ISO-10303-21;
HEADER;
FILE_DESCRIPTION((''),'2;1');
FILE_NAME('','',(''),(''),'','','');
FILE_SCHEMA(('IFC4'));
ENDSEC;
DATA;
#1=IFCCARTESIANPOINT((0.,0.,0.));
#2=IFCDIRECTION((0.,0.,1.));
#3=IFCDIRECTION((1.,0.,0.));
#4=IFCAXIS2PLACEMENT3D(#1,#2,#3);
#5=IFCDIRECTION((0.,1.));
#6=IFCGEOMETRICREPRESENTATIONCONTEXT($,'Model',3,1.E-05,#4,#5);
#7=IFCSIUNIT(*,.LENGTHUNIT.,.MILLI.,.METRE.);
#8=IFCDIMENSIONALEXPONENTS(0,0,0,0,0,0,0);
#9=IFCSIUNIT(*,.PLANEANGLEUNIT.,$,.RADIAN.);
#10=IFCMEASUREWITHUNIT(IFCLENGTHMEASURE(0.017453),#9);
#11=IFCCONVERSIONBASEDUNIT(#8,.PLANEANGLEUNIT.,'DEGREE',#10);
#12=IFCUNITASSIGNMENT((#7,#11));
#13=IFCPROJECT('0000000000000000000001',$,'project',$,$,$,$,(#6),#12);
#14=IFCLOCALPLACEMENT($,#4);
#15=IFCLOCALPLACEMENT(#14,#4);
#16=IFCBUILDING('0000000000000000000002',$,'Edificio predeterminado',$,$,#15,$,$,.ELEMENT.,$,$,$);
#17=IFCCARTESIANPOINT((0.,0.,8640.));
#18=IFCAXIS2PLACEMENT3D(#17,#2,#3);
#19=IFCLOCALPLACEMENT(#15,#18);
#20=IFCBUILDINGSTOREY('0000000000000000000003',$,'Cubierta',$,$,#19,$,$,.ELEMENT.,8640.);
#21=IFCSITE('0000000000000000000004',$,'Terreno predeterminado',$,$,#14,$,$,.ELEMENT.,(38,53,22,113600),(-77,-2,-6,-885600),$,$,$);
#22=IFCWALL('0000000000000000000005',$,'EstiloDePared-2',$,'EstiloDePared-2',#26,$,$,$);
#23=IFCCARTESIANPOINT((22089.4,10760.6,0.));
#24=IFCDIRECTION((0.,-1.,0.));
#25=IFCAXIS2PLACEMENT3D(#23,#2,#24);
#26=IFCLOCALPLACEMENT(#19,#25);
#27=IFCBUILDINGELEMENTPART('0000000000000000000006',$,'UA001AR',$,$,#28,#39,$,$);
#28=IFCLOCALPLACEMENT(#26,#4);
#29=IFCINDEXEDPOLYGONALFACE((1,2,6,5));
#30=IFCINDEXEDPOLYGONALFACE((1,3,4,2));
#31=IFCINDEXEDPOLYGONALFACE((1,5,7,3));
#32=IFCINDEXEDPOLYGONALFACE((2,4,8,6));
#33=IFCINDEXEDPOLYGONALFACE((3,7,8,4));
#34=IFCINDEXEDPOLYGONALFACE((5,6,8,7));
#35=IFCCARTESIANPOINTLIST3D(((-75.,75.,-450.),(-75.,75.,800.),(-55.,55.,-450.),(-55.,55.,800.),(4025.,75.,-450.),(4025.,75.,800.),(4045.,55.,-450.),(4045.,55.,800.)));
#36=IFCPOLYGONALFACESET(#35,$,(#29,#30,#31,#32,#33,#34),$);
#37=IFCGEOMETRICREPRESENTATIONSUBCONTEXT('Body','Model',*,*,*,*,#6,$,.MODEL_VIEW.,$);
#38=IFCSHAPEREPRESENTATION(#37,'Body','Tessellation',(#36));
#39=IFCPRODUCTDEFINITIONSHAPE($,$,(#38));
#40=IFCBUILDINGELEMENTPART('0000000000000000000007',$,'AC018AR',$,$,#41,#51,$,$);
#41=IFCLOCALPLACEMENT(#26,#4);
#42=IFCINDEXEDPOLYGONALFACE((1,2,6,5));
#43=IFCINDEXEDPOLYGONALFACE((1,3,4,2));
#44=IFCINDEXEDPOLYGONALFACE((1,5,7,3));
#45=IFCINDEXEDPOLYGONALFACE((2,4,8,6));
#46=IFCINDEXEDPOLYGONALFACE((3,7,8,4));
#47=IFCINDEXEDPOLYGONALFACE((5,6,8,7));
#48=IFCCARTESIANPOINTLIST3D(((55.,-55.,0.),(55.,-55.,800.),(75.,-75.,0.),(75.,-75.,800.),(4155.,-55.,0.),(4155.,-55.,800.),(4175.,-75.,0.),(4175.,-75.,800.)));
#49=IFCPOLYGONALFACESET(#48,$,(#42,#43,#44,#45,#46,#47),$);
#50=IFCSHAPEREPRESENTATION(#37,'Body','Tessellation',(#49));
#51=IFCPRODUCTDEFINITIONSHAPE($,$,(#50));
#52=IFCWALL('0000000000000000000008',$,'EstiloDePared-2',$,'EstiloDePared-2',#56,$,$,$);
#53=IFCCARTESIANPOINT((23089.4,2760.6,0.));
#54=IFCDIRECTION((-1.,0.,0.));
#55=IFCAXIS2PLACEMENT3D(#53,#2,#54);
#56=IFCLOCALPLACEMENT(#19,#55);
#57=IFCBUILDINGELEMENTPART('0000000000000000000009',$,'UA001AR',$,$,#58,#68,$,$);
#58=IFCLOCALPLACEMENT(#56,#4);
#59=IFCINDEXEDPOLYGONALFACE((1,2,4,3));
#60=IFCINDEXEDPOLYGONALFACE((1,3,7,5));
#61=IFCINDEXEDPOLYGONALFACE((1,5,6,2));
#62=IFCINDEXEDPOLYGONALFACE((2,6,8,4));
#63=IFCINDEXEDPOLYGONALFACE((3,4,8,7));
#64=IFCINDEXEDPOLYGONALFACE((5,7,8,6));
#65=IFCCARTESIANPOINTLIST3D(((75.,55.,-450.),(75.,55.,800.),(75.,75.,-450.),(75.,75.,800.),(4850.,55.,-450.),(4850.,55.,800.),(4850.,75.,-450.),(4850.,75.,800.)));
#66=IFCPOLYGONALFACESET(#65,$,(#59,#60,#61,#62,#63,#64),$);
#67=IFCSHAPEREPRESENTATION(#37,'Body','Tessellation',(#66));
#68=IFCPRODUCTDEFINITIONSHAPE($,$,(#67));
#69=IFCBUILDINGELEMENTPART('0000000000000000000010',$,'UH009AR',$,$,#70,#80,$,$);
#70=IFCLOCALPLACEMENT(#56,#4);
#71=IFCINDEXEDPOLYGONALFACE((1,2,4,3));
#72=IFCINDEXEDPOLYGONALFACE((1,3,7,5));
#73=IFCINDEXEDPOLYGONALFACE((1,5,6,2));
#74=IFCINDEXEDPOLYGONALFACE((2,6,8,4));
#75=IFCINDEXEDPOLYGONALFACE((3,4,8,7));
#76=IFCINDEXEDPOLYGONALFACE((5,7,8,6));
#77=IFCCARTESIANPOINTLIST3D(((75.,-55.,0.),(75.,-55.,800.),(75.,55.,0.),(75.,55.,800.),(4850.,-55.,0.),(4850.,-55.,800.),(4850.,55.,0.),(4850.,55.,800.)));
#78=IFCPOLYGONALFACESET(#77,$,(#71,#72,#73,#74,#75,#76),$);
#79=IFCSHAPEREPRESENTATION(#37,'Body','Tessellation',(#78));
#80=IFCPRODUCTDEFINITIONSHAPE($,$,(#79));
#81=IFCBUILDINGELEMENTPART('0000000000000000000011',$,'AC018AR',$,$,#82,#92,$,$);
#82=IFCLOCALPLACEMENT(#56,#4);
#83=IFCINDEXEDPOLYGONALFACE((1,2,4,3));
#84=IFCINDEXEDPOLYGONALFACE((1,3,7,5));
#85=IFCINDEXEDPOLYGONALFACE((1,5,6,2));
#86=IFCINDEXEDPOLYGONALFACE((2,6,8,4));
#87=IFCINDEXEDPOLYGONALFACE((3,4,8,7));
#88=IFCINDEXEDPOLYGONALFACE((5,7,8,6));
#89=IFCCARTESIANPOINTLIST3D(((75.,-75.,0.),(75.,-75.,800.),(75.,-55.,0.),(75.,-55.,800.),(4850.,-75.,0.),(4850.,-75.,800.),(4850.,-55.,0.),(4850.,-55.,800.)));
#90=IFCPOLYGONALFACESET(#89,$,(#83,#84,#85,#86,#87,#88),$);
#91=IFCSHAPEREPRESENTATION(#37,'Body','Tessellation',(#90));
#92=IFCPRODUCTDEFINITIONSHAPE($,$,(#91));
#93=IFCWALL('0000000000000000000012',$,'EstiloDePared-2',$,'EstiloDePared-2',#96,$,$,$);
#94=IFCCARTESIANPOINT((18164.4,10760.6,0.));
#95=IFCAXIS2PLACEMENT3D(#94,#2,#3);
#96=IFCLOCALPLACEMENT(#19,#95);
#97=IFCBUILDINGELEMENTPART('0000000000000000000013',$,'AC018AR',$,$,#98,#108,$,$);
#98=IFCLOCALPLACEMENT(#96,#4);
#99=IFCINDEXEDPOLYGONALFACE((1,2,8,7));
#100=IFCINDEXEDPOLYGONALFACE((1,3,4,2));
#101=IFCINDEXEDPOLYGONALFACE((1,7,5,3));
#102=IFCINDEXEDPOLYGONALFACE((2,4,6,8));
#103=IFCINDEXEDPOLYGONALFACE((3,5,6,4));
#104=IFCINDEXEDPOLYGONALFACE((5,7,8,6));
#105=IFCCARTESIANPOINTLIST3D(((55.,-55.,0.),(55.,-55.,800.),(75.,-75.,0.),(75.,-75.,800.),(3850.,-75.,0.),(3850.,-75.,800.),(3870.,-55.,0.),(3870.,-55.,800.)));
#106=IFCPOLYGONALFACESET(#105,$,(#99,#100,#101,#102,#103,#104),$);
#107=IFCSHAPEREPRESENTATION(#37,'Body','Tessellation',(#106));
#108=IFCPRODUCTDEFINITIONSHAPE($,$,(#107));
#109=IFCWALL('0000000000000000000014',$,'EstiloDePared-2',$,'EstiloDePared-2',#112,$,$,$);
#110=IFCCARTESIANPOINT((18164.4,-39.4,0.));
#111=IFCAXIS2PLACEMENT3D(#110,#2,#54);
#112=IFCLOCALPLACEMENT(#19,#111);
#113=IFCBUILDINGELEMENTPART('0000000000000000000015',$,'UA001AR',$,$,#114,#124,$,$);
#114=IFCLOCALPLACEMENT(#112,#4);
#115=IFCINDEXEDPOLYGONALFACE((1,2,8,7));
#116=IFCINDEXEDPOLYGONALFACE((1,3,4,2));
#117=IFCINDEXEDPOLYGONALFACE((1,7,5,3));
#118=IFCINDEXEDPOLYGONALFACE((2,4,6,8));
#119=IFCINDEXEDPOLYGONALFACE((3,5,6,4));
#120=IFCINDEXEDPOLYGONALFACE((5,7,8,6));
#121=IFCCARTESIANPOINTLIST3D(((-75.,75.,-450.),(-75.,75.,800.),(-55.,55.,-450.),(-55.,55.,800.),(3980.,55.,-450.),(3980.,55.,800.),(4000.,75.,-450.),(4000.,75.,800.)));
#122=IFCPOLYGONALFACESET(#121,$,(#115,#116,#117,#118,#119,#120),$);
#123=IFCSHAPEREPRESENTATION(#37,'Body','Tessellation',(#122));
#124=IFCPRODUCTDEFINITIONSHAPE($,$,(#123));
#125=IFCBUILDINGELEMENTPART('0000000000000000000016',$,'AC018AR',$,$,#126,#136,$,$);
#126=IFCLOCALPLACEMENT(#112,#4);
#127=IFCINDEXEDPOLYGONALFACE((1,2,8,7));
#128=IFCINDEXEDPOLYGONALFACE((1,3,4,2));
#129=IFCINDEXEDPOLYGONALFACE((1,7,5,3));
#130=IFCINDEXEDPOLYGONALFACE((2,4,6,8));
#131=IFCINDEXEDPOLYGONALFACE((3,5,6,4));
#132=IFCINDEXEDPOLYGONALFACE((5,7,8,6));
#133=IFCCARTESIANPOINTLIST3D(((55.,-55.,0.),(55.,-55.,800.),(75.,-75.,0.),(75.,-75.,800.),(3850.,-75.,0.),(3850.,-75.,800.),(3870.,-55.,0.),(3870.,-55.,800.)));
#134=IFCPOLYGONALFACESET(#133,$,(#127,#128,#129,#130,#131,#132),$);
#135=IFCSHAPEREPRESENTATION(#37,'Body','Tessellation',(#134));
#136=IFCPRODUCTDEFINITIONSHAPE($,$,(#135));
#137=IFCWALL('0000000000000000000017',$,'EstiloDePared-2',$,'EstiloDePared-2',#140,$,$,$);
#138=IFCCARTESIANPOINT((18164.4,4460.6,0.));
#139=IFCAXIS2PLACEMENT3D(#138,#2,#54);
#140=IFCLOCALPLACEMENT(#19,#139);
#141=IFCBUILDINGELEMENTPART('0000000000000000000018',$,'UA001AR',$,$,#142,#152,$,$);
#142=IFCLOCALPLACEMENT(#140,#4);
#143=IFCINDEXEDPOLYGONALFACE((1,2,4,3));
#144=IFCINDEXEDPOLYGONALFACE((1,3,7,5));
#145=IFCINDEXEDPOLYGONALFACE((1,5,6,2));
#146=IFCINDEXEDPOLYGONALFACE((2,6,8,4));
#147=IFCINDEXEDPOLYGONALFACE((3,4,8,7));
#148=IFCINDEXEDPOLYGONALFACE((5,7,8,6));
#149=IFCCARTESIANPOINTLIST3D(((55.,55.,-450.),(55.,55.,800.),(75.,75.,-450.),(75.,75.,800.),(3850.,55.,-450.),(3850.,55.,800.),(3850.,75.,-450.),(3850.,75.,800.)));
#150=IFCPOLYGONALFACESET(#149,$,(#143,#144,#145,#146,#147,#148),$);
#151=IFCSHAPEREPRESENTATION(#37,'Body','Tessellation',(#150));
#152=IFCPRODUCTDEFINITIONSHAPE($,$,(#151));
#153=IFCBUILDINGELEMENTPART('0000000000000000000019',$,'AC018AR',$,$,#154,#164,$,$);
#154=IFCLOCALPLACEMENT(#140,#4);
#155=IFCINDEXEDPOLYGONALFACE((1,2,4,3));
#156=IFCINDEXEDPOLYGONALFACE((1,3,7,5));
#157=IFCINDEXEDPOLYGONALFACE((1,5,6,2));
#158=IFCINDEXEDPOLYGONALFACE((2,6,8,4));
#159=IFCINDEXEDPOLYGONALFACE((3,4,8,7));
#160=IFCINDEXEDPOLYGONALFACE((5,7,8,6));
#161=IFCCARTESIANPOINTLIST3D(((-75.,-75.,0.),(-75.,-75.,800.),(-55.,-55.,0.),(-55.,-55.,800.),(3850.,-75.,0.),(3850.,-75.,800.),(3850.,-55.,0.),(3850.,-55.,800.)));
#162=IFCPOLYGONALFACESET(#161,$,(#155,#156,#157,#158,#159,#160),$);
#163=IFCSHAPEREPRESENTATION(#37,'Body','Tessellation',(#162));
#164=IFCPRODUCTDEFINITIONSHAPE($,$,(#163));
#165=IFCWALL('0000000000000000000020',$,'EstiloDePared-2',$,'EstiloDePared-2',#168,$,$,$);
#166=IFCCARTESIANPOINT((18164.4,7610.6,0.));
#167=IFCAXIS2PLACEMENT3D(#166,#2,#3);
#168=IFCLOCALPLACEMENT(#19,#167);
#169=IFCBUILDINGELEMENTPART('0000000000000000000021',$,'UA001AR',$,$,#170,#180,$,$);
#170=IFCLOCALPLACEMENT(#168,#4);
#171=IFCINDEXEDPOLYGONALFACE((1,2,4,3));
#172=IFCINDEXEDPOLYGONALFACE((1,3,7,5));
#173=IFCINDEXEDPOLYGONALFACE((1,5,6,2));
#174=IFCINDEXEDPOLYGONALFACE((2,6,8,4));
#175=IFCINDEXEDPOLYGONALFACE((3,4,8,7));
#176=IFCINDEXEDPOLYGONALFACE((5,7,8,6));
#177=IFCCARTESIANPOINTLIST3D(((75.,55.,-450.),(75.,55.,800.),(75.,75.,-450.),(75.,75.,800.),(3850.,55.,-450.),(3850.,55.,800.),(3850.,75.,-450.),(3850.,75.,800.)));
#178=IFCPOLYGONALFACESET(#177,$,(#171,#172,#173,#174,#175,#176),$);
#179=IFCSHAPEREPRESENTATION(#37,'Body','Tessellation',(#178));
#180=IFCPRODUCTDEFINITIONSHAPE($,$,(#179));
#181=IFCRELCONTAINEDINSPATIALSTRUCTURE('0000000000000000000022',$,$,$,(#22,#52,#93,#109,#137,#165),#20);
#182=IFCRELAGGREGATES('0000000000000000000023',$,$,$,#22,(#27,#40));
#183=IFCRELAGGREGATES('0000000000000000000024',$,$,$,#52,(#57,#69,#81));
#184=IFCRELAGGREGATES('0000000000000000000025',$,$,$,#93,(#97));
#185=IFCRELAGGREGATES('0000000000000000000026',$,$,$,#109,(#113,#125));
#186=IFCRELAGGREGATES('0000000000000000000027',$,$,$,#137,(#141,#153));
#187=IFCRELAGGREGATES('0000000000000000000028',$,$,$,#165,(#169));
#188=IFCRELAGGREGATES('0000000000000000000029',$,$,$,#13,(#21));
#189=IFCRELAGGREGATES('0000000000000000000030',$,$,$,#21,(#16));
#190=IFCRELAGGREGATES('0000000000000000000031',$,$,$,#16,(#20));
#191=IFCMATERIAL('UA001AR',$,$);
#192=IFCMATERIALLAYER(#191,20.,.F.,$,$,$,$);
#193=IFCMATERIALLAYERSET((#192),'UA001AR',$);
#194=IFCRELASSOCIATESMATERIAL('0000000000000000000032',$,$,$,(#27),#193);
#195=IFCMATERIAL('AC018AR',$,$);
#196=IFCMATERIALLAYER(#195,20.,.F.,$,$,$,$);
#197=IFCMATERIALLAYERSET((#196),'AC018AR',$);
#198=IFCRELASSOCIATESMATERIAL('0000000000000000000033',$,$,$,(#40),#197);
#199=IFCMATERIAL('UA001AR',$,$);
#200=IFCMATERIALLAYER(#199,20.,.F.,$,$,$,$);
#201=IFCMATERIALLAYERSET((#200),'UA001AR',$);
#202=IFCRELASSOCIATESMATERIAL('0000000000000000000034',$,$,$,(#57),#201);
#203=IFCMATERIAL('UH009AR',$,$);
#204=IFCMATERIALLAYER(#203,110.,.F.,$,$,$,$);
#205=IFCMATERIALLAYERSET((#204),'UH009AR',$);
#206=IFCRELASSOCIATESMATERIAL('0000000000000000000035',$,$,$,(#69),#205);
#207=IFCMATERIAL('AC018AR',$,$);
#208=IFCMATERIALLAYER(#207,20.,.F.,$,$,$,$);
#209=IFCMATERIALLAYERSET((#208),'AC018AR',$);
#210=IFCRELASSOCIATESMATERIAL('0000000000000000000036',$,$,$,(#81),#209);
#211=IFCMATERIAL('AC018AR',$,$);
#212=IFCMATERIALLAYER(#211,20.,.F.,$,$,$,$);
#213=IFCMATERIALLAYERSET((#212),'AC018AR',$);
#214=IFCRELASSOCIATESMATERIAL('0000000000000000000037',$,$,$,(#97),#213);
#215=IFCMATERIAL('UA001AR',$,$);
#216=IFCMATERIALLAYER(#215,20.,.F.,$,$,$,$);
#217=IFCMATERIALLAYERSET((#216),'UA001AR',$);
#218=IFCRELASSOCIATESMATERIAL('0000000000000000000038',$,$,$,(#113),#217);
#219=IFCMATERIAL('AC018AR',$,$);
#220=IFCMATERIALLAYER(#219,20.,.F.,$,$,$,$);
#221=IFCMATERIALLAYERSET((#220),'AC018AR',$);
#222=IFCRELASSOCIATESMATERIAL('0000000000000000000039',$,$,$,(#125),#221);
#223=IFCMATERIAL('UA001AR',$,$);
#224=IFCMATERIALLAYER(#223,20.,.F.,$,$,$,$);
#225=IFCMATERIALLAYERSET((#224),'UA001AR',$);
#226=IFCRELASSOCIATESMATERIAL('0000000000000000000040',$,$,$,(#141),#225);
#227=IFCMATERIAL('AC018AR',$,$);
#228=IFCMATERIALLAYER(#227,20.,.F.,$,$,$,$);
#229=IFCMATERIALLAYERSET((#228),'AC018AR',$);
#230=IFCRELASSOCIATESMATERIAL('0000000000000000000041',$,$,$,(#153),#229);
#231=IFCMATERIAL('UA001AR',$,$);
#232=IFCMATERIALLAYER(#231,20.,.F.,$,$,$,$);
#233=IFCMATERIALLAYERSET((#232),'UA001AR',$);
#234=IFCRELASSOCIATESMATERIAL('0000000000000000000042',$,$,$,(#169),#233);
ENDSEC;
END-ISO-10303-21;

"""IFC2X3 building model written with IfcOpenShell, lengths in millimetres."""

from ifc_helpers import new_model, entity, si_unit, converted_unit, direction, frame, origin_with_axes, place, context, subcontext, project, spatial, polyline, outline, extrude, material, layer, layer_set, layer_usage, element, aggregate, save


model = new_model("IFC2X3")

# Units and contexts
model_context = context("Model", 3, precision=1e-05, world=origin_with_axes(), true_north=direction((0.0, 1.0)))
body_context = subcontext(model_context, "Body", "Model", "MODEL_VIEW")
ifc_project = project(units=[si_unit("LENGTHUNIT", "METRE", prefix="MILLI"), converted_unit("PLANEANGLEUNIT", "DEGREE", entity("IfcLengthMeasure", 0.017453), si_unit("PLANEANGLEUNIT", "RADIAN"), dimensions=[0, 0, 0, 0, 0, 0, 0])], contexts=[model_context])

# Site, building, storey
site_placement = place(None, origin_with_axes())
site = spatial("IfcSite", under=ifc_project, at=site_placement, Name="Terreno predeterminado", CompositionType="ELEMENT", RefLatitude=(38, 53, 22, 113600), RefLongitude=(-77, -2, -6, -885600))
building_placement = place(site_placement, origin_with_axes())
building = spatial("IfcBuilding", under=site, at=building_placement, Name="Edificio predeterminado", CompositionType="ELEMENT")
storey_placement = place(building_placement, frame((0.0, 0.0, 8640.0), z_axis=(0.0, 0.0, 1.0), x_axis=(1.0, 0.0, 0.0)))
storey = spatial("IfcBuildingStorey", under=building, at=storey_placement, Name="Cubierta", CompositionType="ELEMENT", Elevation=8640.0)

# Walls, building element parts
wall_1_placement = place(storey_placement, frame((22089.4, 10760.6, 0.0), z_axis=(0.0, 0.0, 1.0), x_axis=(0.0, -1.0, 0.0)))
wall_1 = element("IfcWall", 1, at=wall_1_placement, inside=storey, Name="EstiloDePared-2", ObjectType="EstiloDePared-2")
ifc_material_1 = material(Name="UA001AR")
ifc_layer_1 = layer(ifc_material_1, 20.0, ventilated=False)
ifc_layer_set_1 = layer_set([ifc_layer_1], Name="UA001AR")
ifc_layer_usage_1 = layer_usage(ifc_layer_set_1, "AXIS2", "NEGATIVE", -75.0)
building_element_part_1_placement = place(wall_1_placement, origin_with_axes())
building_element_part_1 = element("IfcBuildingElementPart", 2, at=building_element_part_1_placement, material=ifc_layer_usage_1, Name="UA001AR", context=body_context, shape_type="SweptSolid", body=[
    extrude(outline(polyline([(4025.0, 75.0), (4045.0, 55.0), (-55.0, 55.0), (-75.0, 75.0), (4025.0, 75.0)])), frame((0.0, 0.0, -450.0), z_axis=(0.0, 0.0, 1.0), x_axis=(1.0, 0.0, 0.0)), (0.0, 0.0, 1.0), 1250.0),
])
ifc_material_2 = material(Name="AC018AR")
ifc_layer_2 = layer(ifc_material_2, 20.0, ventilated=False)
ifc_layer_set_2 = layer_set([ifc_layer_2], Name="AC018AR")
ifc_layer_usage_2 = layer_usage(ifc_layer_set_2, "AXIS2", "NEGATIVE", 55.0)
building_element_part_2_placement = place(wall_1_placement, origin_with_axes())
building_element_part_2 = element("IfcBuildingElementPart", 3, at=building_element_part_2_placement, material=ifc_layer_usage_2, Name="AC018AR", context=body_context, shape_type="SweptSolid", body=[
    extrude(outline(polyline([(4155.0, -55.0), (4175.0, -75.0), (75.0, -75.0), (55.0, -55.0), (4155.0, -55.0)])), origin_with_axes(), (0.0, 0.0, 1.0), 800.0),
])
aggregate(wall_1, [building_element_part_1, building_element_part_2])
wall_2_placement = place(storey_placement, frame((23089.4, 2760.6, 0.0), z_axis=(0.0, 0.0, 1.0), x_axis=(-1.0, 0.0, 0.0)))
wall_2 = element("IfcWall", 4, at=wall_2_placement, inside=storey, Name="EstiloDePared-2", ObjectType="EstiloDePared-2")
ifc_material_3 = material(Name="UA001AR")
ifc_layer_3 = layer(ifc_material_3, 20.0, ventilated=False)
ifc_layer_set_3 = layer_set([ifc_layer_3], Name="UA001AR")
ifc_layer_usage_3 = layer_usage(ifc_layer_set_3, "AXIS2", "NEGATIVE", -75.0)
building_element_part_3_placement = place(wall_2_placement, origin_with_axes())
building_element_part_3 = element("IfcBuildingElementPart", 5, at=building_element_part_3_placement, material=ifc_layer_usage_3, Name="UA001AR", context=body_context, shape_type="SweptSolid", body=[
    extrude(outline(polyline([(4850.0, 75.0), (4850.0, 55.0), (75.0, 55.0), (75.0, 75.0), (4850.0, 75.0)])), frame((0.0, 0.0, -450.0), z_axis=(0.0, 0.0, 1.0), x_axis=(1.0, 0.0, 0.0)), (0.0, 0.0, 1.0), 1250.0),
])
ifc_material_4 = material(Name="UH009AR")
ifc_layer_4 = layer(ifc_material_4, 110.0, ventilated=False)
ifc_layer_set_4 = layer_set([ifc_layer_4], Name="UH009AR")
ifc_layer_usage_4 = layer_usage(ifc_layer_set_4, "AXIS2", "NEGATIVE", -55.0)
building_element_part_4_placement = place(wall_2_placement, origin_with_axes())
building_element_part_4 = element("IfcBuildingElementPart", 6, at=building_element_part_4_placement, material=ifc_layer_usage_4, Name="UH009AR", context=body_context, shape_type="SweptSolid", body=[
    extrude(outline(polyline([(4850.0, 55.0), (4850.0, -55.0), (75.0, -55.0), (75.0, 55.0), (4850.0, 55.0)])), origin_with_axes(), (0.0, 0.0, 1.0), 800.0),
])
ifc_material_5 = material(Name="AC018AR")
ifc_layer_5 = layer(ifc_material_5, 20.0, ventilated=False)
ifc_layer_set_5 = layer_set([ifc_layer_5], Name="AC018AR")
ifc_layer_usage_5 = layer_usage(ifc_layer_set_5, "AXIS2", "NEGATIVE", 55.0)
building_element_part_5_placement = place(wall_2_placement, origin_with_axes())
building_element_part_5 = element("IfcBuildingElementPart", 7, at=building_element_part_5_placement, material=ifc_layer_usage_5, Name="AC018AR", context=body_context, shape_type="SweptSolid", body=[
    extrude(outline(polyline([(4850.0, -55.0), (4850.0, -75.0), (75.0, -75.0), (75.0, -55.0), (4850.0, -55.0)])), origin_with_axes(), (0.0, 0.0, 1.0), 800.0),
])
aggregate(wall_2, [building_element_part_3, building_element_part_4, building_element_part_5])

# Wall, building element part
wall_3_placement = place(storey_placement, frame((18164.4, 10760.6, 0.0), z_axis=(0.0, 0.0, 1.0), x_axis=(1.0, 0.0, 0.0)))
wall_3 = element("IfcWall", 8, at=wall_3_placement, inside=storey, Name="EstiloDePared-2", ObjectType="EstiloDePared-2")
ifc_material_6 = material(Name="AC018AR")
ifc_layer_6 = layer(ifc_material_6, 20.0, ventilated=False)
ifc_layer_set_6 = layer_set([ifc_layer_6], Name="AC018AR")
ifc_layer_usage_6 = layer_usage(ifc_layer_set_6, "AXIS2", "NEGATIVE", 55.0)
building_element_part_6_placement = place(wall_3_placement, origin_with_axes())
building_element_part_6 = element("IfcBuildingElementPart", 9, at=building_element_part_6_placement, material=ifc_layer_usage_6, Name="AC018AR", context=body_context, shape_type="SweptSolid", body=[
    extrude(outline(polyline([(3870.0, -55.0), (3850.0, -75.0), (75.0, -75.0), (55.0, -55.0), (3870.0, -55.0)])), origin_with_axes(), (0.0, 0.0, 1.0), 800.0),
])
aggregate(wall_3, [building_element_part_6])

# Walls, building element parts
wall_4_placement = place(storey_placement, frame((18164.4, -39.4, 0.0), z_axis=(0.0, 0.0, 1.0), x_axis=(-1.0, 0.0, 0.0)))
wall_4 = element("IfcWall", 10, at=wall_4_placement, inside=storey, Name="EstiloDePared-2", ObjectType="EstiloDePared-2")
ifc_material_7 = material(Name="UA001AR")
ifc_layer_7 = layer(ifc_material_7, 20.0, ventilated=False)
ifc_layer_set_7 = layer_set([ifc_layer_7], Name="UA001AR")
ifc_layer_usage_7 = layer_usage(ifc_layer_set_7, "AXIS2", "NEGATIVE", -75.0)
building_element_part_7_placement = place(wall_4_placement, origin_with_axes())
building_element_part_7 = element("IfcBuildingElementPart", 11, at=building_element_part_7_placement, material=ifc_layer_usage_7, Name="UA001AR", context=body_context, shape_type="SweptSolid", body=[
    extrude(outline(polyline([(4000.0, 75.0), (3980.0, 55.0), (-55.0, 55.0), (-75.0, 75.0), (4000.0, 75.0)])), frame((0.0, 0.0, -450.0), z_axis=(0.0, 0.0, 1.0), x_axis=(1.0, 0.0, 0.0)), (0.0, 0.0, 1.0), 1250.0),
])
ifc_material_8 = material(Name="AC018AR")
ifc_layer_8 = layer(ifc_material_8, 20.0, ventilated=False)
ifc_layer_set_8 = layer_set([ifc_layer_8], Name="AC018AR")
ifc_layer_usage_8 = layer_usage(ifc_layer_set_8, "AXIS2", "NEGATIVE", 55.0)
building_element_part_8_placement = place(wall_4_placement, origin_with_axes())
building_element_part_8 = element("IfcBuildingElementPart", 12, at=building_element_part_8_placement, material=ifc_layer_usage_8, Name="AC018AR", context=body_context, shape_type="SweptSolid", body=[
    extrude(outline(polyline([(3870.0, -55.0), (3850.0, -75.0), (75.0, -75.0), (55.0, -55.0), (3870.0, -55.0)])), origin_with_axes(), (0.0, 0.0, 1.0), 800.0),
])
aggregate(wall_4, [building_element_part_7, building_element_part_8])
wall_5_placement = place(storey_placement, frame((18164.4, 4460.6, 0.0), z_axis=(0.0, 0.0, 1.0), x_axis=(-1.0, 0.0, 0.0)))
wall_5 = element("IfcWall", 13, at=wall_5_placement, inside=storey, Name="EstiloDePared-2", ObjectType="EstiloDePared-2")
ifc_material_9 = material(Name="UA001AR")
ifc_layer_9 = layer(ifc_material_9, 20.0, ventilated=False)
ifc_layer_set_9 = layer_set([ifc_layer_9], Name="UA001AR")
ifc_layer_usage_9 = layer_usage(ifc_layer_set_9, "AXIS2", "NEGATIVE", -75.0)
building_element_part_9_placement = place(wall_5_placement, origin_with_axes())
building_element_part_9 = element("IfcBuildingElementPart", 14, at=building_element_part_9_placement, material=ifc_layer_usage_9, Name="UA001AR", context=body_context, shape_type="SweptSolid", body=[
    extrude(outline(polyline([(3850.0, 75.0), (3850.0, 55.0), (55.0, 55.0), (75.0, 75.0), (3850.0, 75.0)])), frame((0.0, 0.0, -450.0), z_axis=(0.0, 0.0, 1.0), x_axis=(1.0, 0.0, 0.0)), (0.0, 0.0, 1.0), 1250.0),
])
ifc_material_10 = material(Name="AC018AR")
ifc_layer_10 = layer(ifc_material_10, 20.0, ventilated=False)
ifc_layer_set_10 = layer_set([ifc_layer_10], Name="AC018AR")
ifc_layer_usage_10 = layer_usage(ifc_layer_set_10, "AXIS2", "NEGATIVE", 55.0)
building_element_part_10_placement = place(wall_5_placement, origin_with_axes())
building_element_part_10 = element("IfcBuildingElementPart", 15, at=building_element_part_10_placement, material=ifc_layer_usage_10, Name="AC018AR", context=body_context, shape_type="SweptSolid", body=[
    extrude(outline(polyline([(3850.0, -55.0), (3850.0, -75.0), (-75.0, -75.0), (-55.0, -55.0), (3850.0, -55.0)])), origin_with_axes(), (0.0, 0.0, 1.0), 800.0),
])
aggregate(wall_5, [building_element_part_9, building_element_part_10])
wall_6_placement = place(storey_placement, frame((18164.4, 7610.6, 0.0), z_axis=(0.0, 0.0, 1.0), x_axis=(1.0, 0.0, 0.0)))
wall_6 = element("IfcWall", 16, at=wall_6_placement, inside=storey, Name="EstiloDePared-2", ObjectType="EstiloDePared-2")
ifc_material_11 = material(Name="UA001AR")
ifc_layer_11 = layer(ifc_material_11, 20.0, ventilated=False)
ifc_layer_set_11 = layer_set([ifc_layer_11], Name="UA001AR")
ifc_layer_usage_11 = layer_usage(ifc_layer_set_11, "AXIS2", "NEGATIVE", -75.0)
building_element_part_11_placement = place(wall_6_placement, origin_with_axes())
building_element_part_11 = element("IfcBuildingElementPart", 17, at=building_element_part_11_placement, material=ifc_layer_usage_11, Name="UA001AR", context=body_context, shape_type="SweptSolid", body=[
    extrude(outline(polyline([(3850.0, 75.0), (3850.0, 55.0), (75.0, 55.0), (75.0, 75.0), (3850.0, 75.0)])), frame((0.0, 0.0, -450.0), z_axis=(0.0, 0.0, 1.0), x_axis=(1.0, 0.0, 0.0)), (0.0, 0.0, 1.0), 1250.0),
])
aggregate(wall_6, [building_element_part_11])

save(model, "model.ifc")
